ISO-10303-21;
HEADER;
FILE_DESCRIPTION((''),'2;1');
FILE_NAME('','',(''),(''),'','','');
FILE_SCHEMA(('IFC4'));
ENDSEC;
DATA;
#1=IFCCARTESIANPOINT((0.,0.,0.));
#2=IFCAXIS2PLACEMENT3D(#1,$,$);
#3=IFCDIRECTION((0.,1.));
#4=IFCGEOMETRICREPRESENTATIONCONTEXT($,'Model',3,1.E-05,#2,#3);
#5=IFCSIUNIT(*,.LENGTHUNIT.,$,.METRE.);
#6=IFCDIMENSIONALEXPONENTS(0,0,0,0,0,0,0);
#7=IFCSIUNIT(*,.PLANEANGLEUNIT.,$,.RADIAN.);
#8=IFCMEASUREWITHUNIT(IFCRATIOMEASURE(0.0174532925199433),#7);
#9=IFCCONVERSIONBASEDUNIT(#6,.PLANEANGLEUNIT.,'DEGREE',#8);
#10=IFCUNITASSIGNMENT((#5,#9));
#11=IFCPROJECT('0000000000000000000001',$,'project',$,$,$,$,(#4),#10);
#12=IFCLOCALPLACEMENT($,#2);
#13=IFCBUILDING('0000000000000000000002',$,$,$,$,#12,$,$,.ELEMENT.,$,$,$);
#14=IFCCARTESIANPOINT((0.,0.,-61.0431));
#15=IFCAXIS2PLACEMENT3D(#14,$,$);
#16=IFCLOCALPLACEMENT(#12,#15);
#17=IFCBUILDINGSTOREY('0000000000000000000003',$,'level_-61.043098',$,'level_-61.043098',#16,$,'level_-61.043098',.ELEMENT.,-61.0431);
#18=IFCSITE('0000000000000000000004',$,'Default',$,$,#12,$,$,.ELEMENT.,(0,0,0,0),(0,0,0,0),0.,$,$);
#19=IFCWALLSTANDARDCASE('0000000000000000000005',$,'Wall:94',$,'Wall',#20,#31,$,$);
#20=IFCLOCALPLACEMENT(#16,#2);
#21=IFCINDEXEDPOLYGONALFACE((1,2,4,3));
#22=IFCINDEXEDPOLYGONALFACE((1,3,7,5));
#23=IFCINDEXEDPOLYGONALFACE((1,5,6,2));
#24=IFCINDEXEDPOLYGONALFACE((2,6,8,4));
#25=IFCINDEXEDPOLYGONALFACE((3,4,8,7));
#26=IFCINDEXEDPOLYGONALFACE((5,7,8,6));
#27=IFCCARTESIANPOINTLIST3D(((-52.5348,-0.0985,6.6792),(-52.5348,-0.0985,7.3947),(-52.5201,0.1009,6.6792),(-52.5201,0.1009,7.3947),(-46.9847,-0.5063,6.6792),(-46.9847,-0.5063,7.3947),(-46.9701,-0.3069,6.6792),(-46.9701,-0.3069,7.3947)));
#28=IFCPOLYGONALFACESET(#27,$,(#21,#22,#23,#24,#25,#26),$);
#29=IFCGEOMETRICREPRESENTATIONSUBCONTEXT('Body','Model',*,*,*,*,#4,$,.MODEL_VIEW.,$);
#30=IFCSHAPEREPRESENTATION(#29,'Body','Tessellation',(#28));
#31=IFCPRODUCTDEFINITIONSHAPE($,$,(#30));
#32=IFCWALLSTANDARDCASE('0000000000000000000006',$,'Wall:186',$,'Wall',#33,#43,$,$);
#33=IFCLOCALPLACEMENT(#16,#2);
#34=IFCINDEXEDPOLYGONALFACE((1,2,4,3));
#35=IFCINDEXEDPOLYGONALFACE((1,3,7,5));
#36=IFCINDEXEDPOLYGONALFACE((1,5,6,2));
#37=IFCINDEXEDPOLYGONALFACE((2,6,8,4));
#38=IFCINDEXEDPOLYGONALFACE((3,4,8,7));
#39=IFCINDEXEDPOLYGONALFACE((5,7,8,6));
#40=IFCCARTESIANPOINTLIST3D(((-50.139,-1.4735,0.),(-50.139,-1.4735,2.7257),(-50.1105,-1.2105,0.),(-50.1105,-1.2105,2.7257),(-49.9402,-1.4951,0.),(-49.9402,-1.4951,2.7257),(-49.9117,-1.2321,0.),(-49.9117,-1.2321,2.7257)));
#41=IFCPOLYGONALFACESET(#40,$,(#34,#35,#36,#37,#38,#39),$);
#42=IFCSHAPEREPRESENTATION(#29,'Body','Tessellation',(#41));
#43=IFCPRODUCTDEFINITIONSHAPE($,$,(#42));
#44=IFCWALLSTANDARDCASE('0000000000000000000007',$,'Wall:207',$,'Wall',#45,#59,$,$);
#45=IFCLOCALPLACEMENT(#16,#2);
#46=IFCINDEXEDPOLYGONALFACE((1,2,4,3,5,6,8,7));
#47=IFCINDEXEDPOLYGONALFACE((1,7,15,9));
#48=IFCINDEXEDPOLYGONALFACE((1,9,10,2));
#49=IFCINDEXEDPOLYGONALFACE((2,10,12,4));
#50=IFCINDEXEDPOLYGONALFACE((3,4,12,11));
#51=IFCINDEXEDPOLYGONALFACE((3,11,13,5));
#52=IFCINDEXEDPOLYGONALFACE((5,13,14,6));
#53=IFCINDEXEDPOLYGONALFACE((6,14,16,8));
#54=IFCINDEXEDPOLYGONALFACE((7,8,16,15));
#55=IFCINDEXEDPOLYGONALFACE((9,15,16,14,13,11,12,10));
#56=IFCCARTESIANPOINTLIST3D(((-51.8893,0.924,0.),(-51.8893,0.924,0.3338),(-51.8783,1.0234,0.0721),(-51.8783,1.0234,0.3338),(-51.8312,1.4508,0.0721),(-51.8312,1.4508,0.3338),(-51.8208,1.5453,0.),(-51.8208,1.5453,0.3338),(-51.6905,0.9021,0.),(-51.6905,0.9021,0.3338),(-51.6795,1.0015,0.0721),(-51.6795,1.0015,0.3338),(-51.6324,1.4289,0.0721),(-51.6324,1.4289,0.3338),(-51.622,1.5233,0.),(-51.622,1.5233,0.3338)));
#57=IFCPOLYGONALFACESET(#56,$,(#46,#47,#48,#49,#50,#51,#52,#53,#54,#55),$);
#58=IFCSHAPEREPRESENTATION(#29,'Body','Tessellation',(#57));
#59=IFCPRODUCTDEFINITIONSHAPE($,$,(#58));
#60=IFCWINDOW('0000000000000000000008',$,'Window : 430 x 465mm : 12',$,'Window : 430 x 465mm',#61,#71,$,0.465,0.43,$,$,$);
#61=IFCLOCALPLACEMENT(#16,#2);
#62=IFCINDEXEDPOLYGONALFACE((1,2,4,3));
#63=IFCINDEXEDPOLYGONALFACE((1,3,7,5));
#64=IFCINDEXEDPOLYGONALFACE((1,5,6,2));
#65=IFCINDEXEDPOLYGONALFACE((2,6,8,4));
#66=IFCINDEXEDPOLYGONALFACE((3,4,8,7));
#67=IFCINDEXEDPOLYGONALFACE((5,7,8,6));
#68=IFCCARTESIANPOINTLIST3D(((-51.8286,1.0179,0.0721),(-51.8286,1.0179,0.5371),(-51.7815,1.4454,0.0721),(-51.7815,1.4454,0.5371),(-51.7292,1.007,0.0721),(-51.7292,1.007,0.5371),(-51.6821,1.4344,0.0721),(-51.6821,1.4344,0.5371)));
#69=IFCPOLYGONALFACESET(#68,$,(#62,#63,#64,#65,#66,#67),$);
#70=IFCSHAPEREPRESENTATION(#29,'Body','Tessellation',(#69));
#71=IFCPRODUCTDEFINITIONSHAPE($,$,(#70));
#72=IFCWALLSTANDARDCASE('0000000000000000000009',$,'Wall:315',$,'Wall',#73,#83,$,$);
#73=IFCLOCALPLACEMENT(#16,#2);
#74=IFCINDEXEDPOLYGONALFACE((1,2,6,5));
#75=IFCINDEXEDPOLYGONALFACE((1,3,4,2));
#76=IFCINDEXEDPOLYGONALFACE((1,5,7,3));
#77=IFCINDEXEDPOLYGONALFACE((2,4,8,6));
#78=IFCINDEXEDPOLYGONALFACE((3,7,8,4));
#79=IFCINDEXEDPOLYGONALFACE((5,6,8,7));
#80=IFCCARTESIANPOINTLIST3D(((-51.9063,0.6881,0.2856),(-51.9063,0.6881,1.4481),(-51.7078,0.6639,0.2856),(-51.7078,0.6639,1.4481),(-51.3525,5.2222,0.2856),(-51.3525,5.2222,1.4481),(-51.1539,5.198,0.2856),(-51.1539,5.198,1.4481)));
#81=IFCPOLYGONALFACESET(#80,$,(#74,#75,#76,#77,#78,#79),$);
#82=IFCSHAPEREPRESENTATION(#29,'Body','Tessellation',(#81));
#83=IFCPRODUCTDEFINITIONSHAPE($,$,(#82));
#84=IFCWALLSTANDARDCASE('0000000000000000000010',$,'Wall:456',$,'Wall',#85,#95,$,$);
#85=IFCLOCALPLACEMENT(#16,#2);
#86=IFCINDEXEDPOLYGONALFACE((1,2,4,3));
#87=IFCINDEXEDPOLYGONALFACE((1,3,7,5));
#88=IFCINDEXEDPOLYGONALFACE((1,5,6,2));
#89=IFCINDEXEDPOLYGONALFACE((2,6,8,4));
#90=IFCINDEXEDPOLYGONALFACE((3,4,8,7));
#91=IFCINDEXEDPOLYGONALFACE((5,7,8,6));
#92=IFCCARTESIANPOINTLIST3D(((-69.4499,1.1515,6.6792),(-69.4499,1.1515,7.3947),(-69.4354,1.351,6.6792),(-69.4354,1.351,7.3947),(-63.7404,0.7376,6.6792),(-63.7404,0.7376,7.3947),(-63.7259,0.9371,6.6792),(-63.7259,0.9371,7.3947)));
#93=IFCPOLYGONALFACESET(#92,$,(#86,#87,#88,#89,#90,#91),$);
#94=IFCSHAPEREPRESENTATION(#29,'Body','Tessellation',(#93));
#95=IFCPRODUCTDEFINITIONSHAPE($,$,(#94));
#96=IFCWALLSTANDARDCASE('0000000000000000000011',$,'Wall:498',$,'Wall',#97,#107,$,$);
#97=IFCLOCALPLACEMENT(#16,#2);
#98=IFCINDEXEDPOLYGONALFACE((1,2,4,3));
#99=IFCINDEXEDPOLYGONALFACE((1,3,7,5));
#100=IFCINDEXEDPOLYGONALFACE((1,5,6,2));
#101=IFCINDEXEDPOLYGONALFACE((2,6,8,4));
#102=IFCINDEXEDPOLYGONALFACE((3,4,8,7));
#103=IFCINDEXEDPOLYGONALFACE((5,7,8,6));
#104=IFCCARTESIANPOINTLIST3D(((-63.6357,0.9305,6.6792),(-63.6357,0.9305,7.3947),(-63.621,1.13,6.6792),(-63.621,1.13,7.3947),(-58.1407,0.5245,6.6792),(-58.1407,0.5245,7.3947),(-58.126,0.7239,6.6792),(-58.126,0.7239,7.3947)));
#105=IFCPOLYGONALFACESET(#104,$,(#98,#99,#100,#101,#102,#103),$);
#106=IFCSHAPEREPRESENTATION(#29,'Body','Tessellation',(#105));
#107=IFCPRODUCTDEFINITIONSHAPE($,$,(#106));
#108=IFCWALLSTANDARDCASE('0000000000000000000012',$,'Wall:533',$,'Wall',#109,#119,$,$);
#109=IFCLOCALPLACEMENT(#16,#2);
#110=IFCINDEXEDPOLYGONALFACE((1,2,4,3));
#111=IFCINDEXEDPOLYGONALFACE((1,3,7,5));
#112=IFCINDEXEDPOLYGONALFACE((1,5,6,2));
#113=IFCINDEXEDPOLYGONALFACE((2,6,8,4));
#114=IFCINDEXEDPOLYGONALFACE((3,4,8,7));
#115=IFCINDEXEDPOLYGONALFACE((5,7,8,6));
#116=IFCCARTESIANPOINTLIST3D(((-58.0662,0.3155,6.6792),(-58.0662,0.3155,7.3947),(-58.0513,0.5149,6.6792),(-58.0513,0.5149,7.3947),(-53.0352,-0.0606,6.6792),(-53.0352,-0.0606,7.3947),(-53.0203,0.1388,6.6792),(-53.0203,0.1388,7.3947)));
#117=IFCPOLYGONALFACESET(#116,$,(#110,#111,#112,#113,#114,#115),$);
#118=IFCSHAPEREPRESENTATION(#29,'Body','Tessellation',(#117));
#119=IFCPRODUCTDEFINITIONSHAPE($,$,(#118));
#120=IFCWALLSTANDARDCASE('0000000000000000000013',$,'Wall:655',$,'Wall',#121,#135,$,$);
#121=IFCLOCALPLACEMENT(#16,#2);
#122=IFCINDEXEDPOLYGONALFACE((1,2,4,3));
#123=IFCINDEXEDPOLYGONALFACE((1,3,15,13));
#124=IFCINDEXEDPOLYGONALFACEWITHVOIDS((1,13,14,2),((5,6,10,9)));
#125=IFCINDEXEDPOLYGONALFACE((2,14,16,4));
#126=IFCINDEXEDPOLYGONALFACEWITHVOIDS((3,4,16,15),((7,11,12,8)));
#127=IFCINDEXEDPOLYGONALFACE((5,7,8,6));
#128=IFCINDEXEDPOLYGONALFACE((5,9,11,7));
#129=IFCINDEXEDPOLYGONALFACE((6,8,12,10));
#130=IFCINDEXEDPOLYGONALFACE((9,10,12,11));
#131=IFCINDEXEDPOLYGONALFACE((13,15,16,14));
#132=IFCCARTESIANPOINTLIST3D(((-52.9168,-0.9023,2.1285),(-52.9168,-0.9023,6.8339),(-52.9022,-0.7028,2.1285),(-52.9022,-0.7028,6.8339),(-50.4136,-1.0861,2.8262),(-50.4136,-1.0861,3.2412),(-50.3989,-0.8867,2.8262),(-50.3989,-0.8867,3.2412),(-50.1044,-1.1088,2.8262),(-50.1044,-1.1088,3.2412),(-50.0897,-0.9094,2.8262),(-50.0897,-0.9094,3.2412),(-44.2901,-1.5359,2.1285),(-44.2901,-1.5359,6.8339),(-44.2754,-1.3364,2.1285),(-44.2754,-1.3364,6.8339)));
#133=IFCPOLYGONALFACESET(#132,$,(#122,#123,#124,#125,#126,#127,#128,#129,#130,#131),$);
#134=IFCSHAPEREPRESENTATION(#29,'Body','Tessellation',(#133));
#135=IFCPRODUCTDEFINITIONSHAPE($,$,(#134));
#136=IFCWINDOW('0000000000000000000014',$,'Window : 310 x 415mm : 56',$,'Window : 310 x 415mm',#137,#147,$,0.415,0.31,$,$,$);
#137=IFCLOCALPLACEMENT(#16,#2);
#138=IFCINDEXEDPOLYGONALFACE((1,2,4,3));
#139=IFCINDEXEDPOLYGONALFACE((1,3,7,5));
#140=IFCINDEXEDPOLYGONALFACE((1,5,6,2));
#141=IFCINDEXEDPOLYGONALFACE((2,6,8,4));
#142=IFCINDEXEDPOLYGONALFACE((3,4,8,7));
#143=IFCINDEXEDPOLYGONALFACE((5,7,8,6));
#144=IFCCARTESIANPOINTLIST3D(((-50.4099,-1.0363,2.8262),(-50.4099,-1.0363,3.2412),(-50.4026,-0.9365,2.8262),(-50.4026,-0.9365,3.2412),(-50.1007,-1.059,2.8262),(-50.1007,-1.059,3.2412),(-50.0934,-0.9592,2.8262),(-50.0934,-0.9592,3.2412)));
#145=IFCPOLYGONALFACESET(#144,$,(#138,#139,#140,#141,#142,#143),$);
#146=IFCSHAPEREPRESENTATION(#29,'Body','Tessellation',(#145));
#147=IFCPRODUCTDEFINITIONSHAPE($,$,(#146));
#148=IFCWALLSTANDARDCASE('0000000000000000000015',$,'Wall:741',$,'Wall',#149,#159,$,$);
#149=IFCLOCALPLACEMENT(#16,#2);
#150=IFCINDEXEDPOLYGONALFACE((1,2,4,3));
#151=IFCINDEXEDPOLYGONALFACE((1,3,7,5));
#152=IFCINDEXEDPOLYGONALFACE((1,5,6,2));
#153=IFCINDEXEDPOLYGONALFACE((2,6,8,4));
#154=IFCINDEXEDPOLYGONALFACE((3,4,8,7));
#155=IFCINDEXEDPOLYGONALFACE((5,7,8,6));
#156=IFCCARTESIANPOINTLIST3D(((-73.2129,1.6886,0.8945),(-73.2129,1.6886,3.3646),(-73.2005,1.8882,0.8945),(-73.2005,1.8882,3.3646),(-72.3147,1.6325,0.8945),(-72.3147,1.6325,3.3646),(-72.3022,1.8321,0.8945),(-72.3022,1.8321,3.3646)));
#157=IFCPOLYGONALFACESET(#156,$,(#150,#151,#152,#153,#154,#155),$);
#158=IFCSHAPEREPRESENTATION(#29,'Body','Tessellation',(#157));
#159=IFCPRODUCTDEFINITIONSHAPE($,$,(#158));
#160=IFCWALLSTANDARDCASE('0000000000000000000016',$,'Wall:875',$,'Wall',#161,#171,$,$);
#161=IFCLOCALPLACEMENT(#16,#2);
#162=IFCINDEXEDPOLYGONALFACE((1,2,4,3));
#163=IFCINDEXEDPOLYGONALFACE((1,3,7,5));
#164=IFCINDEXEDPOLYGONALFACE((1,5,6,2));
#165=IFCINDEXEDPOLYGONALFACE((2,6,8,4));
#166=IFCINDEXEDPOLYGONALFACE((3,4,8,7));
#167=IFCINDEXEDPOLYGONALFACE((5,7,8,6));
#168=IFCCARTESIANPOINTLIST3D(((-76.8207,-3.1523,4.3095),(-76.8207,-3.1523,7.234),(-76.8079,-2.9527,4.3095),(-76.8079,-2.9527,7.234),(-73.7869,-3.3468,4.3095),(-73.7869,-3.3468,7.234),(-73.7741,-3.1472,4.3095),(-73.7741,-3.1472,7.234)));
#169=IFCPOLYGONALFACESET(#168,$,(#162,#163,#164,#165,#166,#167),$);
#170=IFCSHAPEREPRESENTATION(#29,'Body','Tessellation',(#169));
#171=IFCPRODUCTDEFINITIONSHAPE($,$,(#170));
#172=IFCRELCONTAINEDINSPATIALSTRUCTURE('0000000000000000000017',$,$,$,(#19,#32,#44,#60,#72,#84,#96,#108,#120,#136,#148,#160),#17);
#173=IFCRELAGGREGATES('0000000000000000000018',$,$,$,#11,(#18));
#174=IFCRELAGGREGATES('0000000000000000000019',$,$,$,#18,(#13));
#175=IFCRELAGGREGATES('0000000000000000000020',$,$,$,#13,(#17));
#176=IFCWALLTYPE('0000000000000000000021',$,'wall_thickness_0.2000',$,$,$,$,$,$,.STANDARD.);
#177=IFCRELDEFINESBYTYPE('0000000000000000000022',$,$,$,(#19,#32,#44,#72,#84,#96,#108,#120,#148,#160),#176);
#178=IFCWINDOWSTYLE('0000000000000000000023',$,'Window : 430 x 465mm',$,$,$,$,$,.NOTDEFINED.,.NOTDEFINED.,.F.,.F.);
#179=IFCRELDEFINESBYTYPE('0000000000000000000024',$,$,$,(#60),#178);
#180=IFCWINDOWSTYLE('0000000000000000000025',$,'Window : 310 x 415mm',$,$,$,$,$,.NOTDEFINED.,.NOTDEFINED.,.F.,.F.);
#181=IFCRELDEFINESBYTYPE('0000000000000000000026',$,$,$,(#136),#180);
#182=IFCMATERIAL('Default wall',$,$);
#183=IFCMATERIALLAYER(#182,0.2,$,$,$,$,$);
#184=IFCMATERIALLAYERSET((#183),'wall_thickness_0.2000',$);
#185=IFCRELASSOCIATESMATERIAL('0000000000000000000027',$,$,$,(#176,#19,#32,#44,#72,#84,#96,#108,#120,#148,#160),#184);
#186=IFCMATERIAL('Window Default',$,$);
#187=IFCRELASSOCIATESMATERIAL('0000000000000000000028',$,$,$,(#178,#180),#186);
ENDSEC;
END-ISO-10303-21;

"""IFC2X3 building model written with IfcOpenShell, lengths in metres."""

from ifc_helpers import new_model, entity, si_unit, converted_unit, direction, frame, frame_2d, origin, origin_2d_with_axis, place, context, subcontext, project, spatial, polyline, rectangle, outline, extrude, source, transform, mapped, material, layer, layer_set, layer_usage, type_object, type_shapes, element, fill, save


model = new_model("IFC2X3")

# Units and contexts
model_context = context("Model", 3, precision=1e-05, world=origin(), true_north=direction((0.0, 1.0)))
body_context = subcontext(model_context, "Body", "Model", "MODEL_VIEW")
ifc_project = project(units=[si_unit("LENGTHUNIT", "METRE"), converted_unit("PLANEANGLEUNIT", "DEGREE", entity("IfcRatioMeasure", 0.0174532925199433), si_unit("PLANEANGLEUNIT", "RADIAN"), dimensions=[0, 0, 0, 0, 0, 0, 0])], contexts=[model_context])

# Site, building, storey
placement_1 = place(None, origin())
site = spatial("IfcSite", under=ifc_project, at=placement_1, Name="Default", CompositionType="ELEMENT", RefLatitude=(0, 0, 0, 0), RefLongitude=(0, 0, 0, 0), RefElevation=0.0)
building = spatial("IfcBuilding", under=site, at=placement_1, CompositionType="ELEMENT")
storey_placement = place(placement_1, frame((0.0, 0.0, -61.0431)))
storey = spatial("IfcBuildingStorey", under=building, at=storey_placement, Name="level_-61.043098", ObjectType="level_-61.043098", LongName="level_-61.043098", CompositionType="ELEMENT", Elevation=-61.0431)

# Walls
ifc_material_1 = material(Name="Default wall")
ifc_layer = layer(ifc_material_1, 0.2)
ifc_layer_set = layer_set([ifc_layer], Name="wall_thickness_0.2000")
ifc_layer_usage = layer_usage(ifc_layer_set, "AXIS2", "POSITIVE", -0.1)
wall_type = type_object("IfcWallType", Name="wall_thickness_0.2000", PredefinedType="STANDARD", material=ifc_layer_set)
placement_2 = place(placement_1, frame((0.0, 0.0, -54.3639)))
wall_1_placement = place(placement_2, frame((-52.5274, 0.0012, 0.0), z_axis=(0.0, 0.0, 1.0), x_axis=(0.997312, -0.073277, 0.0)))
element("IfcWallStandardCase", 1, at=wall_1_placement, inside=storey, type_object=wall_type, material=ifc_layer_usage, Name="Wall:94", ObjectType="Wall", context=body_context, shape_type="SweptSolid", body=[
    extrude(outline(polyline([(5.565, -0.1), (5.565, 0.1), (0.0, 0.1), (0.0, -0.1), (5.565, -0.1)])), origin(), (0.0, 0.0, 1.0), 0.7155),
])
wall_2_placement = place(storey_placement, frame((-50.0396, -1.4843, 0.0), z_axis=(0.0, 0.0, 1.0), x_axis=(0.107744, 0.994179, 0.0)))
element("IfcWallStandardCase", 2, at=wall_2_placement, inside=storey, type_object=wall_type, material=ifc_layer_usage, Name="Wall:186", ObjectType="Wall", context=body_context, shape_type="SweptSolid", body=[
    extrude(outline(polyline([(0.2645, -0.1), (0.2645, 0.1), (0.0, 0.1), (0.0, -0.1), (0.2645, -0.1)])), origin(), (0.0, 0.0, 1.0), 2.7257),
])

# Wall, opening, window
wall_3_placement = place(storey_placement, frame((-51.7214, 1.5343, 0.0), z_axis=(0.0, 0.0, 1.0), x_axis=(-0.109644, -0.993971, 0.0)))
wall_3 = element("IfcWallStandardCase", 3, at=wall_3_placement, inside=storey, type_object=wall_type, material=ifc_layer_usage, Name="Wall:207", ObjectType="Wall", context=body_context, shape_type="SweptSolid", body=[
    extrude(outline(polyline([(0.625, -0.1), (0.625, 0.1), (0.0, 0.1), (0.0, -0.1), (0.625, -0.1)])), origin(), (0.0, 0.0, 1.0), 0.3338),
])
opening_1_placement = place(wall_3_placement, frame((0.095, -0.1, 0.0721)))
opening_1 = element("IfcOpeningElement", 4, at=opening_1_placement, cuts=wall_3, ObjectType="Opening", context=body_context, shape_type="SweptSolid", body=[
    extrude(rectangle(XDim=0.43, YDim=0.465, at=frame_2d((0.2325, 0.215), x_axis=(0.0, 1.0))), frame((0.0, 0.0, 0.0), z_axis=(0.0, 1.0, 0.0), x_axis=(0.0, 0.0, 1.0)), (0.0, 0.0, 1.0), 0.2),
])
ifc_material_2 = material(Name="Window Default")
window_style_1 = type_object("IfcWindowStyle", Name="Window : 430 x 465mm", ConstructionType="NOTDEFINED", OperationType="NOTDEFINED", ParameterTakesPrecedence=False, Sizeable=False, material=ifc_material_2)
shared_shape_1 = source(origin(), body_context, "Body", "SweptSolid", [
    extrude(rectangle(XDim=0.1, YDim=0.43, at=origin_2d_with_axis()), frame((0.215, 0.1, 0.0), z_axis=(0.0, 0.0, 1.0), x_axis=(0.0, 1.0, 0.0)), (0.0, 0.0, 1.0), 0.465),
])
type_shapes(window_style_1, [shared_shape_1])
window_1_placement = place(opening_1_placement, origin())
window_1 = element("IfcWindow", 5, at=window_1_placement, inside=storey, type_object=window_style_1, Name="Window : 430 x 465mm : 12", ObjectType="Window : 430 x 465mm", OverallHeight=0.465, OverallWidth=0.43, context=body_context, shape_type="MappedRepresentation", body=[
    mapped(shared_shape_1, transform((0.0, 0.0, 0.0), scale=1.0)),
])
fill(opening_1, window_1)

# Walls
placement_3 = place(placement_1, frame((0.0, 0.0, -60.7575)))
wall_4_placement = place(placement_3, frame((-51.807, 0.676, 0.0), z_axis=(0.0, 0.0, 1.0), x_axis=(0.121251, 0.992622, 0.0)))
element("IfcWallStandardCase", 6, at=wall_4_placement, inside=storey, type_object=wall_type, material=ifc_layer_usage, Name="Wall:315", ObjectType="Wall", context=body_context, shape_type="SweptSolid", body=[
    extrude(outline(polyline([(4.5678, -0.1), (4.5678, 0.1), (0.0, 0.1), (0.0, -0.1), (4.5678, -0.1)])), origin(), (0.0, 0.0, 1.0), 1.1625),
])
placement_4 = place(placement_1, frame((0.0, 0.0, -54.3639)))
wall_5_placement = place(placement_4, frame((-69.4427, 1.2513, 0.0), z_axis=(0.0, 0.0, 1.0), x_axis=(0.997382, -0.072315, 0.0)))
element("IfcWallStandardCase", 7, at=wall_5_placement, inside=storey, type_object=wall_type, material=ifc_layer_usage, Name="Wall:456", ObjectType="Wall", context=body_context, shape_type="SweptSolid", body=[
    extrude(outline(polyline([(5.7245, -0.1), (5.7245, 0.1), (0.0, 0.1), (0.0, -0.1), (5.7245, -0.1)])), origin(), (0.0, 0.0, 1.0), 0.7155),
])
placement_5 = place(placement_1, frame((0.0, 0.0, -54.3639)))
wall_6_placement = place(placement_5, frame((-63.6283, 1.0303, 0.0), z_axis=(0.0, 0.0, 1.0), x_axis=(0.997281, -0.073696, 0.0)))
element("IfcWallStandardCase", 8, at=wall_6_placement, inside=storey, type_object=wall_type, material=ifc_layer_usage, Name="Wall:498", ObjectType="Wall", context=body_context, shape_type="SweptSolid", body=[
    extrude(outline(polyline([(5.51, -0.1), (5.51, 0.1), (0.0, 0.1), (0.0, -0.1), (5.51, -0.1)])), origin(), (0.0, 0.0, 1.0), 0.7155),
])
placement_6 = place(placement_1, frame((0.0, 0.0, -54.3639)))
wall_7_placement = place(placement_6, frame((-58.0588, 0.4152, 0.0), z_axis=(0.0, 0.0, 1.0), x_axis=(0.997217, -0.074548, 0.0)))
element("IfcWallStandardCase", 9, at=wall_7_placement, inside=storey, type_object=wall_type, material=ifc_layer_usage, Name="Wall:533", ObjectType="Wall", context=body_context, shape_type="SweptSolid", body=[
    extrude(outline(polyline([(5.045, -0.1), (5.045, 0.1), (0.0, 0.1), (0.0, -0.1), (5.045, -0.1)])), origin(), (0.0, 0.0, 1.0), 0.7155),
])

# Wall, opening, window
placement_7 = place(placement_1, frame((0.0, 0.0, -58.9146)))
wall_8_placement = place(placement_7, frame((-52.9095, -0.8026, 0.0), z_axis=(0.0, 0.0, 1.0), x_axis=(0.997314, -0.073245, 0.0)))
wall_8 = element("IfcWallStandardCase", 10, at=wall_8_placement, inside=storey, type_object=wall_type, material=ifc_layer_usage, Name="Wall:655", ObjectType="Wall", context=body_context, shape_type="SweptSolid", body=[
    extrude(outline(polyline([(8.65, -0.1), (8.65, 0.1), (0.0, 0.1), (0.0, -0.1), (8.65, -0.1)])), origin(), (0.0, 0.0, 1.0), 4.7054),
])
opening_2_placement = place(wall_8_placement, frame((2.51, -0.1, 0.6977)))
opening_2 = element("IfcOpeningElement", 11, at=opening_2_placement, cuts=wall_8, ObjectType="Opening", context=body_context, shape_type="SweptSolid", body=[
    extrude(rectangle(XDim=0.31, YDim=0.415, at=frame_2d((0.2075, 0.155), x_axis=(0.0, 1.0))), frame((0.0, 0.0, 0.0), z_axis=(0.0, 1.0, 0.0), x_axis=(0.0, 0.0, 1.0)), (0.0, 0.0, 1.0), 0.2),
])
window_style_2 = type_object("IfcWindowStyle", Name="Window : 310 x 415mm", ConstructionType="NOTDEFINED", OperationType="NOTDEFINED", ParameterTakesPrecedence=False, Sizeable=False, material=ifc_material_2)
shared_shape_2 = source(origin(), body_context, "Body", "SweptSolid", [
    extrude(rectangle(XDim=0.1, YDim=0.31, at=origin_2d_with_axis()), frame((0.155, 0.1, 0.0), z_axis=(0.0, 0.0, 1.0), x_axis=(0.0, 1.0, 0.0)), (0.0, 0.0, 1.0), 0.415),
])
type_shapes(window_style_2, [shared_shape_2])
window_2_placement = place(opening_2_placement, origin())
window_2 = element("IfcWindow", 12, at=window_2_placement, inside=storey, type_object=window_style_2, Name="Window : 310 x 415mm : 56", ObjectType="Window : 310 x 415mm", OverallHeight=0.415, OverallWidth=0.31, context=body_context, shape_type="MappedRepresentation", body=[
    mapped(shared_shape_2, transform((0.0, 0.0, 0.0), scale=1.0)),
])
fill(opening_2, window_2)

# Walls
placement_8 = place(placement_1, frame((0.0, 0.0, -60.1486)))
wall_9_placement = place(placement_8, frame((-73.2067, 1.7884, 0.0), z_axis=(0.0, 0.0, 1.0), x_axis=(0.998059, -0.062282, 0.0)))
element("IfcWallStandardCase", 13, at=wall_9_placement, inside=storey, type_object=wall_type, material=ifc_layer_usage, Name="Wall:741", ObjectType="Wall", context=body_context, shape_type="SweptSolid", body=[
    extrude(outline(polyline([(0.9, -0.1), (0.9, 0.1), (0.0, 0.1), (0.0, -0.1), (0.9, -0.1)])), origin(), (0.0, 0.0, 1.0), 2.4701),
])
placement_9 = place(placement_1, frame((0.0, 0.0, -56.7336)))
wall_10_placement = place(placement_9, frame((-76.8143, -3.0525, 0.0), z_axis=(0.0, 0.0, 1.0), x_axis=(0.997951, -0.063977, 0.0)))
element("IfcWallStandardCase", 14, at=wall_10_placement, inside=storey, type_object=wall_type, material=ifc_layer_usage, Name="Wall:875", ObjectType="Wall", context=body_context, shape_type="SweptSolid", body=[
    extrude(outline(polyline([(3.04, -0.1), (3.04, 0.1), (0.0, 0.1), (0.0, -0.1), (3.04, -0.1)])), origin(), (0.0, 0.0, 1.0), 2.9245),
])

save(model, "model.ifc")
